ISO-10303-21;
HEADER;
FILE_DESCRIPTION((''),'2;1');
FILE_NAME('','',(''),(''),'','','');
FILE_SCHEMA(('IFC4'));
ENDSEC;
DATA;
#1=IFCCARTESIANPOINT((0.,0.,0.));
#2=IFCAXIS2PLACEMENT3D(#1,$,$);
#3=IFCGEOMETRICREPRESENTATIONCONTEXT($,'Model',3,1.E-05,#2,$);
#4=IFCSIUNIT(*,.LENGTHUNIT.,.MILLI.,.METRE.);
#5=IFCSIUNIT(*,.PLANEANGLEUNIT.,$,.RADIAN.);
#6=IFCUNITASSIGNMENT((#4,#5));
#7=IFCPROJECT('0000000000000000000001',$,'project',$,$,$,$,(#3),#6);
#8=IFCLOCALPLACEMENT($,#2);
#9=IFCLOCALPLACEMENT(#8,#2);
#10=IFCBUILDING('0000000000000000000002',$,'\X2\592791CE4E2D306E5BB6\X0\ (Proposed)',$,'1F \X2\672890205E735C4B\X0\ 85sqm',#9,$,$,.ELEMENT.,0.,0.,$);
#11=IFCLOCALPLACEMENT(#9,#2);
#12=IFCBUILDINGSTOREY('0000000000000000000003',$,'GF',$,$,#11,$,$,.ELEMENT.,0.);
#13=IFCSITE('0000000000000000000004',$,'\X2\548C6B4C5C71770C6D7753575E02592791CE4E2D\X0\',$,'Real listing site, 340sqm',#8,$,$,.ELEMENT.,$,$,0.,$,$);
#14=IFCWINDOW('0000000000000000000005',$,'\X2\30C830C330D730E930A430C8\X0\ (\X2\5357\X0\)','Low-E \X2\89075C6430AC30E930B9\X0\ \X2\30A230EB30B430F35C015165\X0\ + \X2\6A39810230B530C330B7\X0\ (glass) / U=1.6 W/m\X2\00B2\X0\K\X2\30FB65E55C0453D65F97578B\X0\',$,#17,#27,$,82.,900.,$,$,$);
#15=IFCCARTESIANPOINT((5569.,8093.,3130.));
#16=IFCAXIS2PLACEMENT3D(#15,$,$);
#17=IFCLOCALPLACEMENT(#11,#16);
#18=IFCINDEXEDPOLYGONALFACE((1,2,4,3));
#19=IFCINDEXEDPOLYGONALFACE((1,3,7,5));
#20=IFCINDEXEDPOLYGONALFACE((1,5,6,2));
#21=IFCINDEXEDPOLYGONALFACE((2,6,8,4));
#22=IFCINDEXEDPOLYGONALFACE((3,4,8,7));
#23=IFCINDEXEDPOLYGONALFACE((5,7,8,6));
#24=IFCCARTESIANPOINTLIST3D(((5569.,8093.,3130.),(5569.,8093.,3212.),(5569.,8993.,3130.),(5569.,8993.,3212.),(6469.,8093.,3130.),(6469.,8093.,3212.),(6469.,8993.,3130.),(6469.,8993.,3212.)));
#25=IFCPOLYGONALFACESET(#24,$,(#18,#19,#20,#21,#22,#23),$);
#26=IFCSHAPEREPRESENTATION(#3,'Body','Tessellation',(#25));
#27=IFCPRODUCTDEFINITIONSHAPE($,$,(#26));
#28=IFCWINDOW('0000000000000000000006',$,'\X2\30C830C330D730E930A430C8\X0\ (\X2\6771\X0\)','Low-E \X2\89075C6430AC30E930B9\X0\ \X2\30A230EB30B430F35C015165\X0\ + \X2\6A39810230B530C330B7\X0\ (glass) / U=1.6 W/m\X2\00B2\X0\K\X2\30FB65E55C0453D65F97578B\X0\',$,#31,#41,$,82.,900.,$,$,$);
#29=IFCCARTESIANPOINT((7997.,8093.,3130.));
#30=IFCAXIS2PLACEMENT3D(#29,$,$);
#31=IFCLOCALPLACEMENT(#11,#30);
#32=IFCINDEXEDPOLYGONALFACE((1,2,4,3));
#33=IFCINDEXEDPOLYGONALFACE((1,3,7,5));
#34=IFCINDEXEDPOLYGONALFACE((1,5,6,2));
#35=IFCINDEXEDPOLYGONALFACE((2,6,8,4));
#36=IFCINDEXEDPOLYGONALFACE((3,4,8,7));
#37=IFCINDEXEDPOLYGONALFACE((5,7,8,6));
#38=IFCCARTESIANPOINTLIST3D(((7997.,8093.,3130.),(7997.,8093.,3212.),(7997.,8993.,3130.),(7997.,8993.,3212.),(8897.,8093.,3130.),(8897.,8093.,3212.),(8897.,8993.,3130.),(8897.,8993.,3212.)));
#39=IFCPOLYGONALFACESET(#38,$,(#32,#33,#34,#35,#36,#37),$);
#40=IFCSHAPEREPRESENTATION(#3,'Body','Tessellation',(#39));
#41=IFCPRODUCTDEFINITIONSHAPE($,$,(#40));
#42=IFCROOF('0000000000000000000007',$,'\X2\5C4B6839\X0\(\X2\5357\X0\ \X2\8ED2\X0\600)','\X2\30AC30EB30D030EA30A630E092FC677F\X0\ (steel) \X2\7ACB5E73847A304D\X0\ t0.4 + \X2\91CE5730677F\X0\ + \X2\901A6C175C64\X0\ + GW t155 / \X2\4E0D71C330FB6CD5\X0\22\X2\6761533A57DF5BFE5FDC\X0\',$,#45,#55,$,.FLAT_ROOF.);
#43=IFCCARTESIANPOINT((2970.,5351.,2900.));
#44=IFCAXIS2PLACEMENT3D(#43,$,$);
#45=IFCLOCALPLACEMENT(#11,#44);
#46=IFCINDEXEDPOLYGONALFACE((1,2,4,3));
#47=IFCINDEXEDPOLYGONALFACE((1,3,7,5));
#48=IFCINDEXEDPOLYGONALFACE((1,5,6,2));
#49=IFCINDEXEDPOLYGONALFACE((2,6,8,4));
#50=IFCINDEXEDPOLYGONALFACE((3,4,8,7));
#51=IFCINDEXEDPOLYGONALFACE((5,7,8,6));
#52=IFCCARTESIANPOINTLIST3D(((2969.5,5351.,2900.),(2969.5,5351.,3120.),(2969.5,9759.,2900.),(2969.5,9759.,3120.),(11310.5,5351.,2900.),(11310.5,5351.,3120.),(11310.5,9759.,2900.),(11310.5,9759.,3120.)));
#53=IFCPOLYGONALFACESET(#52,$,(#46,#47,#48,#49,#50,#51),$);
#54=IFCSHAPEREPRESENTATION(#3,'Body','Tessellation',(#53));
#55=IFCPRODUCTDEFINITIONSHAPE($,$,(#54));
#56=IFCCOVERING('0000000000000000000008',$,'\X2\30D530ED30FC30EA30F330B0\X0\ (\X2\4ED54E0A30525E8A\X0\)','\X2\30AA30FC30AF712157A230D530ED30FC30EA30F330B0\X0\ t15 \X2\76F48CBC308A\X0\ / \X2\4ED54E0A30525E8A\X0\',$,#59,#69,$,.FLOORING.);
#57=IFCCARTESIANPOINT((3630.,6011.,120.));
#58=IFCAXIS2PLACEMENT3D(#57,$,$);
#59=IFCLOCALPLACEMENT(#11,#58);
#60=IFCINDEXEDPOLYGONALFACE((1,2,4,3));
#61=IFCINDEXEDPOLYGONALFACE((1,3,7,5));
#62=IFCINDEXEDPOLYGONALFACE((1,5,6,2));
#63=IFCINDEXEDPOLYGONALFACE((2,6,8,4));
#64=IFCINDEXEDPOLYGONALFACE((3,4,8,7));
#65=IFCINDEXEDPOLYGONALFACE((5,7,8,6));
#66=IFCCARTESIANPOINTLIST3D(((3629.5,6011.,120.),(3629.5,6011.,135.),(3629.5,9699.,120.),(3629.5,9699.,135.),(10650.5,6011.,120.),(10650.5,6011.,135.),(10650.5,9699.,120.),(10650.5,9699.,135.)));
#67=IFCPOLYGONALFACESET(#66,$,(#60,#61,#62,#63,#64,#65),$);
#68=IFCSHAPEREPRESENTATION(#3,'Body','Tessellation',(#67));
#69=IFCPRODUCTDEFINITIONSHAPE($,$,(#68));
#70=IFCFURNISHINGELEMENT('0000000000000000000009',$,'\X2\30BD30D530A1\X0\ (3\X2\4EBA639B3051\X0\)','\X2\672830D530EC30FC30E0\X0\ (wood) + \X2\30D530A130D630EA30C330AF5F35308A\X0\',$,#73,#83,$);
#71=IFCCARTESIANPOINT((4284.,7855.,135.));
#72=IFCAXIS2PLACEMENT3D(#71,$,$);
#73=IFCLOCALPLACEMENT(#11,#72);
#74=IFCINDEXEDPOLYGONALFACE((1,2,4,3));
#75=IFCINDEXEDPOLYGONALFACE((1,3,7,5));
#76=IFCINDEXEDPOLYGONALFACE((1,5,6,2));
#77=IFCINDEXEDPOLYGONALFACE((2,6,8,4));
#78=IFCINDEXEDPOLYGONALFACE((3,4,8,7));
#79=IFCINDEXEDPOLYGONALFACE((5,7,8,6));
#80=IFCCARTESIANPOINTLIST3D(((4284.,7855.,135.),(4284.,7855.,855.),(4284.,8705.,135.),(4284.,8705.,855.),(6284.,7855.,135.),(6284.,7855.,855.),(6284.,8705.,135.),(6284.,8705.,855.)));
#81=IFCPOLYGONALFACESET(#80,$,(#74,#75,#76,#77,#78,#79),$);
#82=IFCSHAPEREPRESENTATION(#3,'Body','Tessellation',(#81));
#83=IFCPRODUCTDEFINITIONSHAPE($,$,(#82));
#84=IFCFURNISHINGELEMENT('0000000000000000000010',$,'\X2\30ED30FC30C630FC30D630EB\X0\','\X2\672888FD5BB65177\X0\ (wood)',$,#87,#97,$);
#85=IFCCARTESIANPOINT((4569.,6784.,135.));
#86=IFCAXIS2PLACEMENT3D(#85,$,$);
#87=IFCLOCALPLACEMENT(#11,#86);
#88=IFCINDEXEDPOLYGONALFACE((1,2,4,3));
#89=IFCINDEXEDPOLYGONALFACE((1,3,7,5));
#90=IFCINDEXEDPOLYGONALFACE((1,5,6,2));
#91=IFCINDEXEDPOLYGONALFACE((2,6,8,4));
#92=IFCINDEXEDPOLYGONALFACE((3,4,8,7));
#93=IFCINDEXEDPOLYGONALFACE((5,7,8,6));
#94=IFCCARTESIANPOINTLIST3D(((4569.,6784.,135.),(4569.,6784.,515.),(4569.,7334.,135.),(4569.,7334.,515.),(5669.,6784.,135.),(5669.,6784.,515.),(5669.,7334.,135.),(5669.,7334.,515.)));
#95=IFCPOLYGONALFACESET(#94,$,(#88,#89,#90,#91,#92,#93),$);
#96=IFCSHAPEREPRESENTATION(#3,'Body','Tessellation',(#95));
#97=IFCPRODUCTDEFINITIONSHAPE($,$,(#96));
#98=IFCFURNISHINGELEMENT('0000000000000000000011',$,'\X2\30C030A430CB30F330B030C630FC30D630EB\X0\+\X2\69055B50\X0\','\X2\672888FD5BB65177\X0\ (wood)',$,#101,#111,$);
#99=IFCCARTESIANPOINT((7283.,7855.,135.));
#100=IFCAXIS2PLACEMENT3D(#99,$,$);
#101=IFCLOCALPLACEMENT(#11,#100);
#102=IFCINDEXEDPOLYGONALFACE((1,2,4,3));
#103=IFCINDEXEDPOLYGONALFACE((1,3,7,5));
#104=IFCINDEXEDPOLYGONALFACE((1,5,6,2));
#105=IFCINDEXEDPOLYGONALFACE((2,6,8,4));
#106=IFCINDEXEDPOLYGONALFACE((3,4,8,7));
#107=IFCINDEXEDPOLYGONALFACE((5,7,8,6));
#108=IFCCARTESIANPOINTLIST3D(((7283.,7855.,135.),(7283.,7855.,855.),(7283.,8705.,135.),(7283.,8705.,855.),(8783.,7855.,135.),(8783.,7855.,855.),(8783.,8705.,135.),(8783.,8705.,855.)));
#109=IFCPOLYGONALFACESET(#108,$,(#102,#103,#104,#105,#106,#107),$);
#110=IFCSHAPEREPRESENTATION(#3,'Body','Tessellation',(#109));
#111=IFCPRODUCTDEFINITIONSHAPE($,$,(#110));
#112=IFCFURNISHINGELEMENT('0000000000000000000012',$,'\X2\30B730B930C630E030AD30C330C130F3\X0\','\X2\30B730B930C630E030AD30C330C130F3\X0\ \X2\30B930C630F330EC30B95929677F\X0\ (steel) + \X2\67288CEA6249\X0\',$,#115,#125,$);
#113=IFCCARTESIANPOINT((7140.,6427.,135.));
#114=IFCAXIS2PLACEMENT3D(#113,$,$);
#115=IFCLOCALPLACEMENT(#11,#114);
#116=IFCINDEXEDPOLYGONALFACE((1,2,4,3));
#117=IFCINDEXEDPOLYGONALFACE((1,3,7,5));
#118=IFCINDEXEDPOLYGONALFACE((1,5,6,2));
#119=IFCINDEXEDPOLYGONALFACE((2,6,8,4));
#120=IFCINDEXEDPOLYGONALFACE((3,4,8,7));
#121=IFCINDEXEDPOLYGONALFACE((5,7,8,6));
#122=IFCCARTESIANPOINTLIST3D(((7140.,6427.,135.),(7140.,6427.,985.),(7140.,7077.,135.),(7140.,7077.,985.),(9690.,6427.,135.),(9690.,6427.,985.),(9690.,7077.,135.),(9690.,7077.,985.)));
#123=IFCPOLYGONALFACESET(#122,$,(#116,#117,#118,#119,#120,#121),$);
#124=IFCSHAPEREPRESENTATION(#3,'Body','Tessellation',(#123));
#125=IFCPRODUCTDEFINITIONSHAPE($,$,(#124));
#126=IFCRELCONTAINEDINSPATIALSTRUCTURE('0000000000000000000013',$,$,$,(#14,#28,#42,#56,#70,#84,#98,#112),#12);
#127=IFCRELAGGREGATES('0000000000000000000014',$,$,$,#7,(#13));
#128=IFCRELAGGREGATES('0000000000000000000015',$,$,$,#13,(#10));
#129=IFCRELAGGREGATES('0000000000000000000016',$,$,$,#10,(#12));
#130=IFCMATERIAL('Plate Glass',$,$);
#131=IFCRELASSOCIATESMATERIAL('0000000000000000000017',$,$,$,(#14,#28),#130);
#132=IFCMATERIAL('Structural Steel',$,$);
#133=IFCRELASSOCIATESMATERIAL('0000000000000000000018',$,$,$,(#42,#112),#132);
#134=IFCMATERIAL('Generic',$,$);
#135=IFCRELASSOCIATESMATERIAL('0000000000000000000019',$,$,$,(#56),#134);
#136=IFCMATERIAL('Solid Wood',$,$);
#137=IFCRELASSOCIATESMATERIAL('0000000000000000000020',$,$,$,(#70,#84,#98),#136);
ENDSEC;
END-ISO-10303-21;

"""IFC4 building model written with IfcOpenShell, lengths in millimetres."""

from ifc_helpers import new_model, si_unit, frame, frame_2d, origin, place, context, project, spatial, rectangle, extrude, material, element, save


model = new_model("IFC4")

# Units and contexts
model_context = context("Model", 3, precision=1e-05, world=origin())
ifc_project = project(units=[si_unit("LENGTHUNIT", "METRE", prefix="MILLI"), si_unit("PLANEANGLEUNIT", "RADIAN")], contexts=[model_context])

# Site, building, storey
site_placement = place(None, origin())
site = spatial("IfcSite", under=ifc_project, at=site_placement, Name="和歌山県海南市大野中", ObjectType="Real listing site, 340sqm", CompositionType="ELEMENT", RefElevation=0.0)
building_placement = place(site_placement, origin())
building = spatial("IfcBuilding", under=site, at=building_placement, Name="大野中の家 (Proposed)", ObjectType="1F 木造平屋 85sqm", CompositionType="ELEMENT", ElevationOfRefHeight=0.0, ElevationOfTerrain=0.0)
storey_placement = place(building_placement, origin())
storey = spatial("IfcBuildingStorey", under=building, at=storey_placement, Name="GF", CompositionType="ELEMENT", Elevation=0.0)

# Shared definitions
ifc_material_1 = material(Name="Solid Wood")

# Shared definitions
ifc_material_2 = material(Name="Plate Glass")

# Windows
window_1_placement = place(storey_placement, frame((5569.0, 8093.0, 3130.0)))
element("IfcWindow", 1, at=window_1_placement, inside=storey, material=ifc_material_2, Name="トップライト (南)", Description="Low-E 複層ガラス アルゴン封入 + 樹脂サッシ (glass) / U=1.6 W/m²K・日射取得型", OverallHeight=82.0, OverallWidth=900.0, context=model_context, shape_type="SweptSolid", body=[
    extrude(rectangle(XDim=900.0, YDim=900.0, at=frame_2d((450.0, 450.0))), frame((5569.0, 8093.0, 3130.0)), (0.0, 0.0, 1.0), 82.0),
])
window_2_placement = place(storey_placement, frame((7997.0, 8093.0, 3130.0)))
element("IfcWindow", 2, at=window_2_placement, inside=storey, material=ifc_material_2, Name="トップライト (東)", Description="Low-E 複層ガラス アルゴン封入 + 樹脂サッシ (glass) / U=1.6 W/m²K・日射取得型", OverallHeight=82.0, OverallWidth=900.0, context=model_context, shape_type="SweptSolid", body=[
    extrude(rectangle(XDim=900.0, YDim=900.0, at=frame_2d((450.0, 450.0))), frame((7997.0, 8093.0, 3130.0)), (0.0, 0.0, 1.0), 82.0),
])

# Roof
ifc_material_3 = material(Name="Structural Steel")
roof_placement = place(storey_placement, frame((2970.0, 5351.0, 2900.0)))
element("IfcRoof", 3, at=roof_placement, inside=storey, material=ifc_material_3, Name="屋根(南 軒600)", Description="ガルバリウム鋼板 (steel) 立平葺き t0.4 + 野地板 + 通気層 + GW t155 / 不燃・法22条区域対応", PredefinedType="FLAT_ROOF", context=model_context, shape_type="SweptSolid", body=[
    extrude(rectangle(XDim=8341.0, YDim=4408.0, at=frame_2d((4170.0, 2204.0))), frame((2970.0, 5351.0, 2900.0)), (0.0, 0.0, 1.0), 220.0),
])

# Covering
ifc_material_4 = material(Name="Generic")
covering_placement = place(storey_placement, frame((3630.0, 6011.0, 120.0)))
element("IfcCovering", 4, at=covering_placement, inside=storey, material=ifc_material_4, Name="フローリング (仕上げ床)", Description="オーク無垢フローリング t15 直貼り / 仕上げ床", PredefinedType="FLOORING", context=model_context, shape_type="SweptSolid", body=[
    extrude(rectangle(XDim=7021.0, YDim=3688.0, at=frame_2d((3510.0, 1844.0))), frame((3630.0, 6011.0, 120.0)), (0.0, 0.0, 1.0), 15.0),
])

# Furnishing elements
furnishing_1_placement = place(storey_placement, frame((4284.0, 7855.0, 135.0)))
element("IfcFurnishingElement", 5, at=furnishing_1_placement, inside=storey, material=ifc_material_1, Name="ソファ (3人掛け)", Description="木フレーム (wood) + ファブリック張り", context=model_context, shape_type="SweptSolid", body=[
    extrude(rectangle(XDim=2000.0, YDim=850.0, at=frame_2d((1000.0, 425.0))), frame((4284.0, 7855.0, 135.0)), (0.0, 0.0, 1.0), 720.0),
])
furnishing_2_placement = place(storey_placement, frame((4569.0, 6784.0, 135.0)))
element("IfcFurnishingElement", 6, at=furnishing_2_placement, inside=storey, material=ifc_material_1, Name="ローテーブル", Description="木製家具 (wood)", context=model_context, shape_type="SweptSolid", body=[
    extrude(rectangle(XDim=1100.0, YDim=550.0, at=frame_2d((550.0, 275.0))), frame((4569.0, 6784.0, 135.0)), (0.0, 0.0, 1.0), 380.0),
])
furnishing_3_placement = place(storey_placement, frame((7283.0, 7855.0, 135.0)))
element("IfcFurnishingElement", 7, at=furnishing_3_placement, inside=storey, material=ifc_material_1, Name="ダイニングテーブル+椅子", Description="木製家具 (wood)", context=model_context, shape_type="SweptSolid", body=[
    extrude(rectangle(XDim=1500.0, YDim=850.0, at=frame_2d((750.0, 425.0))), frame((7283.0, 7855.0, 135.0)), (0.0, 0.0, 1.0), 720.0),
])
furnishing_4_placement = place(storey_placement, frame((7140.0, 6427.0, 135.0)))
element("IfcFurnishingElement", 8, at=furnishing_4_placement, inside=storey, material=ifc_material_3, Name="システムキッチン", Description="システムキッチン ステンレス天板 (steel) + 木質扉", context=model_context, shape_type="SweptSolid", body=[
    extrude(rectangle(XDim=2550.0, YDim=650.0, at=frame_2d((1275.0, 325.0))), frame((7140.0, 6427.0, 135.0)), (0.0, 0.0, 1.0), 850.0),
])

save(model, "model.ifc")
